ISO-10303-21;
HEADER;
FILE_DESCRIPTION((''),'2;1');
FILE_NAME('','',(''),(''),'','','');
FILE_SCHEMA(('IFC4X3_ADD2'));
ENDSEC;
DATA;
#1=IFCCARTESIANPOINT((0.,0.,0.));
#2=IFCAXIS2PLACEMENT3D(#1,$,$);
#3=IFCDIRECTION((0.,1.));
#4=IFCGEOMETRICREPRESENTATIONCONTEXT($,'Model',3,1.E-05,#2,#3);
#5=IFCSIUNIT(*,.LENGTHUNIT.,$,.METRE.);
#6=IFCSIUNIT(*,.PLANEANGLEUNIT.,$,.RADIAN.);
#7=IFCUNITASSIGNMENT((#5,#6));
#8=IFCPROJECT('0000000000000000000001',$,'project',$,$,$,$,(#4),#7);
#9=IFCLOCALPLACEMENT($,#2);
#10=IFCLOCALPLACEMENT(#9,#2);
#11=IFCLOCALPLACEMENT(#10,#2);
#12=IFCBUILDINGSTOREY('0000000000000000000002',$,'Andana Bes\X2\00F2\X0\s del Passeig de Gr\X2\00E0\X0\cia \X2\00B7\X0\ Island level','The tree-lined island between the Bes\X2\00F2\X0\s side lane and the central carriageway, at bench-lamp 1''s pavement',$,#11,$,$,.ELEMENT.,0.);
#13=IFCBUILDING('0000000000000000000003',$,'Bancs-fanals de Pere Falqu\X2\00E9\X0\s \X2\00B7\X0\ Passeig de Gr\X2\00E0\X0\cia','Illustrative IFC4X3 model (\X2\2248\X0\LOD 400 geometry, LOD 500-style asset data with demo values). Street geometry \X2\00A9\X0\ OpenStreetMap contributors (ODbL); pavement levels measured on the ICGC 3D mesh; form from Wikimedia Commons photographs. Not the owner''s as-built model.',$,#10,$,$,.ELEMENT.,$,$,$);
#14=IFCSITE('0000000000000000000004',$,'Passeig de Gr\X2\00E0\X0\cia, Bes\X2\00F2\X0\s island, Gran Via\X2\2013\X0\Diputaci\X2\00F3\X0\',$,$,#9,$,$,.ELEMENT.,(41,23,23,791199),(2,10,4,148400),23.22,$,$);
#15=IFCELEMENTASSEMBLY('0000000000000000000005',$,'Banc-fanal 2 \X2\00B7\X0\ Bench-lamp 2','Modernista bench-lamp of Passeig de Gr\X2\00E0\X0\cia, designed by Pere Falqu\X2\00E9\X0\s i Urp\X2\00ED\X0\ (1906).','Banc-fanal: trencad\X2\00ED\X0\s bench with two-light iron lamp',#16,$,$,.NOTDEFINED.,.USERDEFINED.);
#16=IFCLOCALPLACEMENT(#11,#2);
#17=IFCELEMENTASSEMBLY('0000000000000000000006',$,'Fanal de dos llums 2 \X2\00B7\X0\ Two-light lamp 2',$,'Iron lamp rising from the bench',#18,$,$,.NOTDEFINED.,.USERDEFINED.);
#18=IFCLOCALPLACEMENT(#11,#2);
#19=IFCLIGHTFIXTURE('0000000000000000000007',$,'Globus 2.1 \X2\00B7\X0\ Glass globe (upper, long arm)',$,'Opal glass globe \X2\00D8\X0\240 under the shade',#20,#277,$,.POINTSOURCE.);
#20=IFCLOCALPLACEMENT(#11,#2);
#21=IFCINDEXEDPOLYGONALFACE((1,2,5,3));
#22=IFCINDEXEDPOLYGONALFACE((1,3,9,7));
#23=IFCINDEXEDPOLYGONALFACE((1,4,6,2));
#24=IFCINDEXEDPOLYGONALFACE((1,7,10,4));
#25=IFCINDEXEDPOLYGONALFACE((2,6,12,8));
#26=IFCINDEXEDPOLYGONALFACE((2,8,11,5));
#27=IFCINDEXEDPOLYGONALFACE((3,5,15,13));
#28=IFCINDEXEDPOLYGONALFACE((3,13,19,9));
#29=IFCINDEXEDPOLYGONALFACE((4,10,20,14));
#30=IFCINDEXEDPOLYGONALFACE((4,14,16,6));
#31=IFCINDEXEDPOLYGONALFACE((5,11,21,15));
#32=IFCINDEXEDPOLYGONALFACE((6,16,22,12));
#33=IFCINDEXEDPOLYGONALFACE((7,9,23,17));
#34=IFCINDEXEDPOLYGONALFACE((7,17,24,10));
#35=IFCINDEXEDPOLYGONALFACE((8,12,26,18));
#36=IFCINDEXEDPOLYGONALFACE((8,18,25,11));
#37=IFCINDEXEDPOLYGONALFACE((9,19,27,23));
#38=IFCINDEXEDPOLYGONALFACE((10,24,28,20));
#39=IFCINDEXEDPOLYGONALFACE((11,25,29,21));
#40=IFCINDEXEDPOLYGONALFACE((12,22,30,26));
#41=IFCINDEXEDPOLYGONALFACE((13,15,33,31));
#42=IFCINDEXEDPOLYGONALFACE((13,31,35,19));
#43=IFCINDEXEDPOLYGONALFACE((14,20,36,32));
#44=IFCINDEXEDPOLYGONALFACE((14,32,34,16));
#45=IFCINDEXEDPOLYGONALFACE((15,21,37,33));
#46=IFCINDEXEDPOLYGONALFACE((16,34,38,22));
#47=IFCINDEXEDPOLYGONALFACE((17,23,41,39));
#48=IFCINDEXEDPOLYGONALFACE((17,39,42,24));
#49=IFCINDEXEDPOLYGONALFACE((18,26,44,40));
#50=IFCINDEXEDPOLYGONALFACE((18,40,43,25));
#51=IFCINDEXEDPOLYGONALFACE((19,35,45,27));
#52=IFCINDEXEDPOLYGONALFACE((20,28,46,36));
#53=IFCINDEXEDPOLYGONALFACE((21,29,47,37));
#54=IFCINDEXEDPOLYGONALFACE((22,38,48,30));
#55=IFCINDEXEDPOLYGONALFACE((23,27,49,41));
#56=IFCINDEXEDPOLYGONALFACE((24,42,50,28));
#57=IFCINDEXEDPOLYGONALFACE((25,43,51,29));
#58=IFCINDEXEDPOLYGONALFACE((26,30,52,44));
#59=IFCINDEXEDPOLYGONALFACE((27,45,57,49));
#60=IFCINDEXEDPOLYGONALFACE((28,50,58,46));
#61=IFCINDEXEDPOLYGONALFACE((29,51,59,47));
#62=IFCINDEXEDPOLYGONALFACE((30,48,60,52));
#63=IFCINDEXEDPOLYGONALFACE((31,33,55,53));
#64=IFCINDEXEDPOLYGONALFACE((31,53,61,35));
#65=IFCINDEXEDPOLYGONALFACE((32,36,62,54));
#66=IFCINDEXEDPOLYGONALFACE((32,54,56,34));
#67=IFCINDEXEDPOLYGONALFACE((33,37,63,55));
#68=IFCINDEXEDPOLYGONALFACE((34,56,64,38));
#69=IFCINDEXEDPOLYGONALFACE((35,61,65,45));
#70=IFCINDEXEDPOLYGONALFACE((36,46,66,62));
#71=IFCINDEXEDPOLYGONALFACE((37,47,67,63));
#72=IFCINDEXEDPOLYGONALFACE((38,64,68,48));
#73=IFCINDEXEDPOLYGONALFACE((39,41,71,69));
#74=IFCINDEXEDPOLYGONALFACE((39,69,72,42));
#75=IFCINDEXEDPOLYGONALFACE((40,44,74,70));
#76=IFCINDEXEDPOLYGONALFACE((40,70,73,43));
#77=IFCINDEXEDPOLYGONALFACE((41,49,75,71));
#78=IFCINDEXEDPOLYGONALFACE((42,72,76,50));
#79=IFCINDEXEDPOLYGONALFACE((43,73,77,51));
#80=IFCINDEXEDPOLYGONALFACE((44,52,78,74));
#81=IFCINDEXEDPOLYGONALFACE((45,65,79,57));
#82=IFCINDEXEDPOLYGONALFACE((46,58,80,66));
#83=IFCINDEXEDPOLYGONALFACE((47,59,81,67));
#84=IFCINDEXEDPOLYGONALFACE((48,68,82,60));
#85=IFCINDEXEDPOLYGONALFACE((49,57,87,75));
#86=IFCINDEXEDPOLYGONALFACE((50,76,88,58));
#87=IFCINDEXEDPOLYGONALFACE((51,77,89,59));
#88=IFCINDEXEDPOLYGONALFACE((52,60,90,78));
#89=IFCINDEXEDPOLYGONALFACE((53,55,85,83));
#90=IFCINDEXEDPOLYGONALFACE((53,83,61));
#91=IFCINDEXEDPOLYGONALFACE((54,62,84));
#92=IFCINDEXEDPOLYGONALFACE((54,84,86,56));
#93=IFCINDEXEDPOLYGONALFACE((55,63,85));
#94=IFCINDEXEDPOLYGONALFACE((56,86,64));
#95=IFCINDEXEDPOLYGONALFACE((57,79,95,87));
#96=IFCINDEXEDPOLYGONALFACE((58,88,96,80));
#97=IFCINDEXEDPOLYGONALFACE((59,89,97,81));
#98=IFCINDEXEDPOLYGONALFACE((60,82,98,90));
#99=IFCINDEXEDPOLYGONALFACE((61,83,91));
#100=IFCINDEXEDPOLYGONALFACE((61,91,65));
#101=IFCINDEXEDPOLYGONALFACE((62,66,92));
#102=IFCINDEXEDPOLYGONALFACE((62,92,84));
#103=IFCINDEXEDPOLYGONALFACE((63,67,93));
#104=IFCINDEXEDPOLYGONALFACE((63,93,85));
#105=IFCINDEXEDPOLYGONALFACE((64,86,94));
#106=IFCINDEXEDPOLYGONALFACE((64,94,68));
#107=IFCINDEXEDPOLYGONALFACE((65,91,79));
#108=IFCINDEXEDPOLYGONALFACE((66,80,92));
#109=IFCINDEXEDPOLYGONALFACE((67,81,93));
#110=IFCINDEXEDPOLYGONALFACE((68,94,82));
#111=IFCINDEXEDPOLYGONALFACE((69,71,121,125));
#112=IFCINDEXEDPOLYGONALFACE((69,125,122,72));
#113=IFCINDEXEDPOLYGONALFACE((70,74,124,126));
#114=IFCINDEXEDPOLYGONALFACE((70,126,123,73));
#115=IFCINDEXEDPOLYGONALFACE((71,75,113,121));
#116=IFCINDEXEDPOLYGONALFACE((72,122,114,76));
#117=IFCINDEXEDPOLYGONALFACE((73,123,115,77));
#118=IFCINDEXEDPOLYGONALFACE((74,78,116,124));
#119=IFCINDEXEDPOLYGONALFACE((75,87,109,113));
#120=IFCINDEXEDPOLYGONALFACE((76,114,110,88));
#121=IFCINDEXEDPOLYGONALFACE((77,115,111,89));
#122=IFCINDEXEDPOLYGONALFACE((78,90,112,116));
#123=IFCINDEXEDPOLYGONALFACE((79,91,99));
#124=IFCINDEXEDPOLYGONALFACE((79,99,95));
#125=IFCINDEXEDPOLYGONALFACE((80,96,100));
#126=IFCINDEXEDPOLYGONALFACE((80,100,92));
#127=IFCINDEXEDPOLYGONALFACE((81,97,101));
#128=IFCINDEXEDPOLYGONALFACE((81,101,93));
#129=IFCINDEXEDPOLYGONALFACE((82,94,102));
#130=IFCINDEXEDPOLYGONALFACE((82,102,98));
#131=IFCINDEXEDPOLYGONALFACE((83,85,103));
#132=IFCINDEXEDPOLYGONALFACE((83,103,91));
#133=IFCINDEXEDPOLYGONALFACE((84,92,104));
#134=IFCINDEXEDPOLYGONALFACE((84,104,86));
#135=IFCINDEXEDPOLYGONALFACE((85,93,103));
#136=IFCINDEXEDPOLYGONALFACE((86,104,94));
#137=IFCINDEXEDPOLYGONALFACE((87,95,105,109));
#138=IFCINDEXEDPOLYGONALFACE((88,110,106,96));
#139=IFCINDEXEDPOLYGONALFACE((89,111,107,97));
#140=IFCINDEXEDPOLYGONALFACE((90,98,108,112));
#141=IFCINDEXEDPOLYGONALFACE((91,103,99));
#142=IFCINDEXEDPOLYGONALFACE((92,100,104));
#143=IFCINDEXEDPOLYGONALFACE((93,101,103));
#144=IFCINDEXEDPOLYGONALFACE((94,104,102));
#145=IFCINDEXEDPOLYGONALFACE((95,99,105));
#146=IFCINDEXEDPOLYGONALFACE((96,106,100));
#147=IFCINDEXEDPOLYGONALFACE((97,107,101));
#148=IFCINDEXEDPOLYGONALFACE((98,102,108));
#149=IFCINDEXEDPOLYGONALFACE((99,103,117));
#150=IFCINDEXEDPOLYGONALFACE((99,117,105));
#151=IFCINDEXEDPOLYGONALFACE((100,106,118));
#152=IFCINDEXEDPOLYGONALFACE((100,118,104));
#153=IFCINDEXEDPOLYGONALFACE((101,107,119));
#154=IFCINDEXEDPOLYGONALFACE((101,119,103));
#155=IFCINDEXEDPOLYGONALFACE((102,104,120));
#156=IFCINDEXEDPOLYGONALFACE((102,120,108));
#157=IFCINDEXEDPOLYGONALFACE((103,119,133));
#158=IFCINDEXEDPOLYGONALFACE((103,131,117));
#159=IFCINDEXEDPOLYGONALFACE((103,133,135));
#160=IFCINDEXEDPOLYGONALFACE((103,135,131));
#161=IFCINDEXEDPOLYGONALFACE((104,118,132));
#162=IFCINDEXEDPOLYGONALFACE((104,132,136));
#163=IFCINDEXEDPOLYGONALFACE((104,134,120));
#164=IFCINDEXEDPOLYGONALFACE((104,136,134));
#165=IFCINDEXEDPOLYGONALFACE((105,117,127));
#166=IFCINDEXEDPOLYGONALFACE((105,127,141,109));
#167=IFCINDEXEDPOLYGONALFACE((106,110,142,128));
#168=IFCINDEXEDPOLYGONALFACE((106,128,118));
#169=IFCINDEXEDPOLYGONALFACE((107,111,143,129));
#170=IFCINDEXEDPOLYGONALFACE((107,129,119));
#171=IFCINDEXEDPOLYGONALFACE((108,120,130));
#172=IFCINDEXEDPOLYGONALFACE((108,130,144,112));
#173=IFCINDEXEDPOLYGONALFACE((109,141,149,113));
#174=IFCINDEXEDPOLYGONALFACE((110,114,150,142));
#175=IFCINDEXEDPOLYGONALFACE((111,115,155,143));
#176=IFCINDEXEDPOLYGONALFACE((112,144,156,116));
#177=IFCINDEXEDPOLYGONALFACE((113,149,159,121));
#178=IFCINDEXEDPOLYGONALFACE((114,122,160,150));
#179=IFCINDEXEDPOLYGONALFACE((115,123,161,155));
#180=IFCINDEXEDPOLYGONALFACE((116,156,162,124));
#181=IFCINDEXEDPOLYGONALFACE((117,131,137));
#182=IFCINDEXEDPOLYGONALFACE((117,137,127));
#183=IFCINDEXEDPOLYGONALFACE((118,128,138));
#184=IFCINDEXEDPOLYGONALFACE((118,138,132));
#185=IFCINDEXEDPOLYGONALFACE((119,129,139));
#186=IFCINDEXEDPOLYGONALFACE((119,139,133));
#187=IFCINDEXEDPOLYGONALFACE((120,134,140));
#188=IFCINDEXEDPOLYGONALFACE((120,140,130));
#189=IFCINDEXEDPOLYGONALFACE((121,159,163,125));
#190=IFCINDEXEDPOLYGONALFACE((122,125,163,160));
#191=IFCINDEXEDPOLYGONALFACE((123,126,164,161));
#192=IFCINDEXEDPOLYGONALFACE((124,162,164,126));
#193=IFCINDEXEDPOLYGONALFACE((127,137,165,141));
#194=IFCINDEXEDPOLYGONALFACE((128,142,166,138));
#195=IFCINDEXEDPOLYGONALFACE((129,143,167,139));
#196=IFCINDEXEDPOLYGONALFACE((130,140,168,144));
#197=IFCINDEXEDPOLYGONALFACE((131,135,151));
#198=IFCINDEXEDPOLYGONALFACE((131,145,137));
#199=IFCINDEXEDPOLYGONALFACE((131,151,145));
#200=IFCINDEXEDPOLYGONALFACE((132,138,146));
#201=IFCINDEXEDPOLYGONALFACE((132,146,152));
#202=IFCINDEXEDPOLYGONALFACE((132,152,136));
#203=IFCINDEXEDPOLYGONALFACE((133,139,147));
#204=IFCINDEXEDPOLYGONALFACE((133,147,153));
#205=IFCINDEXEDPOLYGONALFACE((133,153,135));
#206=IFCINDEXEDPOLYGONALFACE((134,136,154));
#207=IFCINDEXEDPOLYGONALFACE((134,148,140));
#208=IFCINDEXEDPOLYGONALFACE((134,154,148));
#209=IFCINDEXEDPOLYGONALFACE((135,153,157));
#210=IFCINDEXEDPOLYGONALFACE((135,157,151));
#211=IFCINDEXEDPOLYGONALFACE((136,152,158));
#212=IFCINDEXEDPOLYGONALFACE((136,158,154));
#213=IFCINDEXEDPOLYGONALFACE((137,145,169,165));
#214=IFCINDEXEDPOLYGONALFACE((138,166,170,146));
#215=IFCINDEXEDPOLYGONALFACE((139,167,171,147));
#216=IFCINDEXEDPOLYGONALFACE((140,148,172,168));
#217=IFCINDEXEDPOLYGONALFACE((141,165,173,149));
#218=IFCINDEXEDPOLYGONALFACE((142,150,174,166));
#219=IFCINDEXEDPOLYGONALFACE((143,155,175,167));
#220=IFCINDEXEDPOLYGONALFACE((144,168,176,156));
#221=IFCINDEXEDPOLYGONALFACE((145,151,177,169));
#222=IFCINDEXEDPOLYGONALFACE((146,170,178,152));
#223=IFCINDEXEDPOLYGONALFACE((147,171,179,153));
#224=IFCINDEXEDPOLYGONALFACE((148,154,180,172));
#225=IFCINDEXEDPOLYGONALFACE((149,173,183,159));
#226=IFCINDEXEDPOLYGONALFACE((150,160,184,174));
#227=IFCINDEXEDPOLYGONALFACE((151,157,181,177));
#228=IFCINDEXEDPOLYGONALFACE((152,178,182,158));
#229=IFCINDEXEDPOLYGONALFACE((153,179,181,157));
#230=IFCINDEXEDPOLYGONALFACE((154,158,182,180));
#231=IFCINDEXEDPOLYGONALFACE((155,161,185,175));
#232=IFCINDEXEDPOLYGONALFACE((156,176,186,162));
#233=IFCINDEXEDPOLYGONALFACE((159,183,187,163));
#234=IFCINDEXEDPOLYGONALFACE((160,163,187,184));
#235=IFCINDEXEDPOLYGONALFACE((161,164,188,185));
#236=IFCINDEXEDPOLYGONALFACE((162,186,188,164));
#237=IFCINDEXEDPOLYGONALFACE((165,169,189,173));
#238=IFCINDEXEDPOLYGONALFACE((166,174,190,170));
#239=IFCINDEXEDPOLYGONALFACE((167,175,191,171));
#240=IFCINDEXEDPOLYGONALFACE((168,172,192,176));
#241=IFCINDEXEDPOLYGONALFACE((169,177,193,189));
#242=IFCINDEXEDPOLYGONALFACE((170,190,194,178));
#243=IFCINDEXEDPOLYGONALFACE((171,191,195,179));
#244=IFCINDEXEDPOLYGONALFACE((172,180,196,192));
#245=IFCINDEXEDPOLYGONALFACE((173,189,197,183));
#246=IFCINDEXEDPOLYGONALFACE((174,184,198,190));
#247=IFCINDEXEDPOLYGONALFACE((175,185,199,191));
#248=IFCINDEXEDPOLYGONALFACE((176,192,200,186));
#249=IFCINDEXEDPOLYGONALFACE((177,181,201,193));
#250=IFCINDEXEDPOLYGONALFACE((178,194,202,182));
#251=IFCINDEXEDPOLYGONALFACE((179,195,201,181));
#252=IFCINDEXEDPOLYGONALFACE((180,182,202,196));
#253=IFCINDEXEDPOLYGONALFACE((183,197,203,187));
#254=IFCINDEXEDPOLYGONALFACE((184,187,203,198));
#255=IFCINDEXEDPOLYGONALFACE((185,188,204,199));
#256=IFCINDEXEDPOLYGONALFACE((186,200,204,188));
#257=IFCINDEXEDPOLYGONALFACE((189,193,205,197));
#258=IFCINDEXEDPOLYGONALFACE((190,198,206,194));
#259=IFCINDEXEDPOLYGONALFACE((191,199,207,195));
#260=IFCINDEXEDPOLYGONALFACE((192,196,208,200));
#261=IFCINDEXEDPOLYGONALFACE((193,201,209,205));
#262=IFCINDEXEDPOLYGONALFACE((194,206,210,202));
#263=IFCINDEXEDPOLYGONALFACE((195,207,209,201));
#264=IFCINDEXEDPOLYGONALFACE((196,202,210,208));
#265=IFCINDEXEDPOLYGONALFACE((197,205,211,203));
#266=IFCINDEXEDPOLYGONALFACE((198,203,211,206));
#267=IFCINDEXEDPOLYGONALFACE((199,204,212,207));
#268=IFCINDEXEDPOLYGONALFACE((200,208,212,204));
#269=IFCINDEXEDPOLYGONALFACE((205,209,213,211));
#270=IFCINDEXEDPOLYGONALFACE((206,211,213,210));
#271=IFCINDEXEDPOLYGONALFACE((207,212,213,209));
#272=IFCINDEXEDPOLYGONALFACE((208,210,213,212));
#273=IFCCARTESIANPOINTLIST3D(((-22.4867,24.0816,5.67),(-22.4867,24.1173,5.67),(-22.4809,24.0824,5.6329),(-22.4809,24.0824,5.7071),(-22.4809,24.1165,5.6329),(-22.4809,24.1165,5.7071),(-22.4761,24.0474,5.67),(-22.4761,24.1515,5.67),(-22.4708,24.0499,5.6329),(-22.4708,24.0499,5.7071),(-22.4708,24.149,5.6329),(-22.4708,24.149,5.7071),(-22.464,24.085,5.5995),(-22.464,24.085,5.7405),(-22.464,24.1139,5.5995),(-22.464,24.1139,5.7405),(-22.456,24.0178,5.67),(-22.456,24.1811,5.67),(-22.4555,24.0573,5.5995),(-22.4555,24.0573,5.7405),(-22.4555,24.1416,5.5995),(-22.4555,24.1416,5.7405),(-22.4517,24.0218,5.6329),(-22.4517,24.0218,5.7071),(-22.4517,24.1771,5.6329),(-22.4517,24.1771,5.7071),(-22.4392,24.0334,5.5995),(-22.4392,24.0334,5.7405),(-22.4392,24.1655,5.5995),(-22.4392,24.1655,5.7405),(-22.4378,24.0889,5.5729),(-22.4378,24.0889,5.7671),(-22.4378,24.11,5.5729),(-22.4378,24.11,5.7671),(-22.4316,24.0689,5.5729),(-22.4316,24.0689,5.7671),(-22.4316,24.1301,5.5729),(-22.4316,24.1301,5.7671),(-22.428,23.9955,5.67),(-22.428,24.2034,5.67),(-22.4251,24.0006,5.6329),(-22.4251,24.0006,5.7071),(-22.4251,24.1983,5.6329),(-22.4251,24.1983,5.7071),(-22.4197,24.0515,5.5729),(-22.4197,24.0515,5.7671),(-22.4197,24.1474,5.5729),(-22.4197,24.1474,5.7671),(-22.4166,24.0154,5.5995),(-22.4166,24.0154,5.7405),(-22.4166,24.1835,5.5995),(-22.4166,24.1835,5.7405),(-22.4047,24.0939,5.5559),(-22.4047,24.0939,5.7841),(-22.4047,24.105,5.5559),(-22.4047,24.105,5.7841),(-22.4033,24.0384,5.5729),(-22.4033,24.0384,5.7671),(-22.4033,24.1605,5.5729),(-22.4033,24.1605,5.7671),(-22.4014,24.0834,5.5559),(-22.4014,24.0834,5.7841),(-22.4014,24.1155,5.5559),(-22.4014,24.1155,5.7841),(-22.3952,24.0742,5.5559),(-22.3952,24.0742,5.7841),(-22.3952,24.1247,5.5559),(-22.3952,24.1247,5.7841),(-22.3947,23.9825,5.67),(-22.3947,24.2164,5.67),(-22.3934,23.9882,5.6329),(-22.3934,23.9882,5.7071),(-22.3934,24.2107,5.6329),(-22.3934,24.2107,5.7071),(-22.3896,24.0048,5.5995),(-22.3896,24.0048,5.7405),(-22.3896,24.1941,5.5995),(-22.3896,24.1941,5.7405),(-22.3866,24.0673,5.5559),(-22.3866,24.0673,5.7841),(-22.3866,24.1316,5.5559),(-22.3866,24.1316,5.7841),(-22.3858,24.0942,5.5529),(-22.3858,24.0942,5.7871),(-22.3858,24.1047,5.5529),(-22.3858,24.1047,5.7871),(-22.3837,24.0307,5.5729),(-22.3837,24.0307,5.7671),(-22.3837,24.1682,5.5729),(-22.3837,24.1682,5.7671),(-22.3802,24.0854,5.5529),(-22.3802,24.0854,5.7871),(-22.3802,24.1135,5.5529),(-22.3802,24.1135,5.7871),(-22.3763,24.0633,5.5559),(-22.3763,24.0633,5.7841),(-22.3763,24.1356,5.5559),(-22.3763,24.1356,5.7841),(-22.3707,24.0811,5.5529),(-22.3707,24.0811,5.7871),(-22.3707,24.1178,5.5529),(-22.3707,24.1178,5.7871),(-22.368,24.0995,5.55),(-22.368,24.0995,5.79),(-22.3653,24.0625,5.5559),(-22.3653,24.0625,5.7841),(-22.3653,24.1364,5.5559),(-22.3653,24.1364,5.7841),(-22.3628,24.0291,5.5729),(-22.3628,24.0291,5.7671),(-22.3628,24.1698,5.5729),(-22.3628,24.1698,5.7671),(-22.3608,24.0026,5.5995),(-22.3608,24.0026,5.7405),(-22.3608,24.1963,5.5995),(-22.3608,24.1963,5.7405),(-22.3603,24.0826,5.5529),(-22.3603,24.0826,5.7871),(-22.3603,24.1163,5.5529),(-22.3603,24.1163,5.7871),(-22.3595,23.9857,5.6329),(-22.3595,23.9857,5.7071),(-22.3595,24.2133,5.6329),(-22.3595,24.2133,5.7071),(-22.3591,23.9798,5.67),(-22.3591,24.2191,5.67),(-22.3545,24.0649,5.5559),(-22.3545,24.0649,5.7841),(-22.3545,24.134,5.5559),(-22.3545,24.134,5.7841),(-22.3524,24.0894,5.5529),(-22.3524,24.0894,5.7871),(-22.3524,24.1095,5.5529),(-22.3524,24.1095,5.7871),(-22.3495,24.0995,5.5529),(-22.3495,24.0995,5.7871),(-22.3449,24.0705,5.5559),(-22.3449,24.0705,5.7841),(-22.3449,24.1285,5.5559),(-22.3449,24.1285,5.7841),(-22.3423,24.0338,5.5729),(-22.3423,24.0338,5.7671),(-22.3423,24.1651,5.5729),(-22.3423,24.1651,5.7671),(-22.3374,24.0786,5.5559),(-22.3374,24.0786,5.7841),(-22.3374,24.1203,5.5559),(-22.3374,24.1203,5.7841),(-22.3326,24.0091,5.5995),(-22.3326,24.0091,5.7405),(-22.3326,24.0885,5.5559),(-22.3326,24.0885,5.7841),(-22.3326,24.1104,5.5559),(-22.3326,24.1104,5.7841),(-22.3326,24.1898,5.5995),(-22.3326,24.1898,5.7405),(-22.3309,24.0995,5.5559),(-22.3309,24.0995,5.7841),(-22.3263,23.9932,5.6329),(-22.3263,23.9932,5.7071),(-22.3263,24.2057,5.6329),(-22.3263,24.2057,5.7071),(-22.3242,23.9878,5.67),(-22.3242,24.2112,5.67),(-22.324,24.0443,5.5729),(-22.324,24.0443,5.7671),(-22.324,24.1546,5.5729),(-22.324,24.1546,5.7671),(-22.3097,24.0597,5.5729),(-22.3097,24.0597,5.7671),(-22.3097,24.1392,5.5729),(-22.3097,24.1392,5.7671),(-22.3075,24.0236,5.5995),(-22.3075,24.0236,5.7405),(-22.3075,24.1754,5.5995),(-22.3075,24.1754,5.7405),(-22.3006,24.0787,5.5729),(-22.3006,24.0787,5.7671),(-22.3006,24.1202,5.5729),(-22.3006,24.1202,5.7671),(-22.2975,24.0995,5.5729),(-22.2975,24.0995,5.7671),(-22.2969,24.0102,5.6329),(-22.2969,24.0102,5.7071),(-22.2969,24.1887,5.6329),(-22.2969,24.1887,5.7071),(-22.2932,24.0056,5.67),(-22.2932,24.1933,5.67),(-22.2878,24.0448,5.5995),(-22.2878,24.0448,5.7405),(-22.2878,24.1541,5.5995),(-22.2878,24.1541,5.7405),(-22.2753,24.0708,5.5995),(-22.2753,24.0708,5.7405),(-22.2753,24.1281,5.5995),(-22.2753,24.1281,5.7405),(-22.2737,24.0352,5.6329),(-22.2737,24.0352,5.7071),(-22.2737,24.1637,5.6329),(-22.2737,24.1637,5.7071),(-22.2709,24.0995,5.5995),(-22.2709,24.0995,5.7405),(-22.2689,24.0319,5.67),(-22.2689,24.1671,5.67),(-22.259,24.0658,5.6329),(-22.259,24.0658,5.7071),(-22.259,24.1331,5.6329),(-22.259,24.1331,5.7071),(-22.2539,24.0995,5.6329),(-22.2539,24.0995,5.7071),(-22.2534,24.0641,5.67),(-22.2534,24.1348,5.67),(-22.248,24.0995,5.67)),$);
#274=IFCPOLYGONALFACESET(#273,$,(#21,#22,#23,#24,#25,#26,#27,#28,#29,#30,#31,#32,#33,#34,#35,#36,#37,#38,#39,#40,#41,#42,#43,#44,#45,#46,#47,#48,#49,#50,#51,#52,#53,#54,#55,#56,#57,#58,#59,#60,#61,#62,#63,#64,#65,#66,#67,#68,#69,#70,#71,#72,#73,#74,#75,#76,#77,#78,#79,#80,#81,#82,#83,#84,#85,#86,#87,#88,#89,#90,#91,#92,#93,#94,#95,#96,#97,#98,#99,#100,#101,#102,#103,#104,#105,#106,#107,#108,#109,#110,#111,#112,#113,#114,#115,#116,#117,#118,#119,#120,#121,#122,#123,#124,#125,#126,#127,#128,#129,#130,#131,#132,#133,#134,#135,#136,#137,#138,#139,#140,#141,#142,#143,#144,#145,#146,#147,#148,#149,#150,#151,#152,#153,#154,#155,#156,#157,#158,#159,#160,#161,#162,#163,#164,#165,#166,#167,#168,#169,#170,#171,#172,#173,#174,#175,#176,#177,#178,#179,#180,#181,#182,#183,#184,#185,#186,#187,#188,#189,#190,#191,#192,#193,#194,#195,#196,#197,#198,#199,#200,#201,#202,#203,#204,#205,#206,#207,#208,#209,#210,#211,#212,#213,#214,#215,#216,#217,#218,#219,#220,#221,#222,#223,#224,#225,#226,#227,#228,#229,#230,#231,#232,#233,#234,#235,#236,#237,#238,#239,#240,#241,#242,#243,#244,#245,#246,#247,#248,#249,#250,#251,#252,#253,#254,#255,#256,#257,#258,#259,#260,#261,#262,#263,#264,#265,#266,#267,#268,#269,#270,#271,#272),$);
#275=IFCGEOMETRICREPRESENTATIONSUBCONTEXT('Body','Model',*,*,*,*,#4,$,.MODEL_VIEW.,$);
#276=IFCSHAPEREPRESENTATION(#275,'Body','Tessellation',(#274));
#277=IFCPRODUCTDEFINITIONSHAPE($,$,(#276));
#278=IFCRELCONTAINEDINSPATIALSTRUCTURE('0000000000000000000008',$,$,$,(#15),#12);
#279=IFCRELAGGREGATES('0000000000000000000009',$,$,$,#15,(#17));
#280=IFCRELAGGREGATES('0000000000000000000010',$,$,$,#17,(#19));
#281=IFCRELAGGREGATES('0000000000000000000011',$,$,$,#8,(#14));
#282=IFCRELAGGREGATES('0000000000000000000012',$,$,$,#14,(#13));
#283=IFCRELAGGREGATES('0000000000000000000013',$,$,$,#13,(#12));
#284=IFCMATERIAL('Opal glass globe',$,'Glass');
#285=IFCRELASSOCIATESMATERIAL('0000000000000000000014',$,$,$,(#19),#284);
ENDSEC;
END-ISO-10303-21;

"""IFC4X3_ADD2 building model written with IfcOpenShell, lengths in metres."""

from ifc_helpers import new_model, entity, si_unit, direction, origin, place, context, subcontext, project, spatial, material, element, aggregate, save


model = new_model("IFC4X3_ADD2")

# Units and contexts
model_context = context("Model", 3, precision=1e-05, world=origin(), true_north=direction((0.0, 1.0)))
body_context = subcontext(model_context, "Body", "Model", "MODEL_VIEW")
ifc_project = project(units=[si_unit("LENGTHUNIT", "METRE"), si_unit("PLANEANGLEUNIT", "RADIAN")], contexts=[model_context])

# Site, building, storey
site_placement = place(None, origin())
site = spatial("IfcSite", under=ifc_project, at=site_placement, Name="Passeig de Gràcia, Besòs island, Gran Via–Diputació", CompositionType="ELEMENT", RefLatitude=(41, 23, 23, 791199), RefLongitude=(2, 10, 4, 148400), RefElevation=23.22)
building_placement = place(site_placement, origin())
building = spatial("IfcBuilding", under=site, at=building_placement, Name="Bancs-fanals de Pere Falqués · Passeig de Gràcia", Description="Illustrative IFC4X3 model (≈LOD 400 geometry, LOD 500-style asset data with demo values). Street geometry © OpenStreetMap contributors (ODbL); pavement levels measured on the ICGC 3D mesh; form from Wikimedia Commons photographs. Not the owner's as-built model.", CompositionType="ELEMENT")
storey_placement = place(building_placement, origin())
storey = spatial("IfcBuildingStorey", under=building, at=storey_placement, Name="Andana Besòs del Passeig de Gràcia · Island level", Description="The tree-lined island between the Besòs side lane and the central carriageway, at bench-lamp 1's pavement", CompositionType="ELEMENT", Elevation=0.0)

# Element assemblies
assembly_1_placement = place(building_placement, origin())
assembly_1 = element("IfcElementAssembly", 1, at=assembly_1_placement, inside=storey, Name="Banc-fanal 2 · Bench-lamp 2", Description="Modernista bench-lamp of Passeig de Gràcia, designed by Pere Falqués i Urpí (1906).", ObjectType="Banc-fanal: trencadís bench with two-light iron lamp", AssemblyPlace="NOTDEFINED", PredefinedType="USERDEFINED")
assembly_2_placement = place(building_placement, origin())
assembly_2 = element("IfcElementAssembly", 2, at=assembly_2_placement, Name="Fanal de dos llums 2 · Two-light lamp 2", ObjectType="Iron lamp rising from the bench", AssemblyPlace="NOTDEFINED", PredefinedType="USERDEFINED")
aggregate(assembly_1, [assembly_2])

# Light fixture
ifc_material_1 = material(Name="Opal glass globe", Category="Glass")
light_fixture_1_placement = place(building_placement, origin())
light_fixture_1 = element("IfcLightFixture", 3, at=light_fixture_1_placement, material=ifc_material_1, Name="Globus 2.1 · Glass globe (upper, long arm)", ObjectType="Opal glass globe Ø240 under the shade", PredefinedType="POINTSOURCE", context=body_context, shape_type="SweptSolid", body=[
    entity("IfcRevolvedAreaSolid", entity("IfcArbitraryClosedProfileDef", "AREA", None, entity("IfcPolyline", [entity("IfcCartesianPoint", [0.0, -0.12]), entity("IfcCartesianPoint", [0.0371, -0.1141]), entity("IfcCartesianPoint", [0.0705, -0.0971]), entity("IfcCartesianPoint", [0.0971, -0.0705]), entity("IfcCartesianPoint", [0.1141, -0.0371]), entity("IfcCartesianPoint", [0.12, 0.0]), entity("IfcCartesianPoint", [0.1141, 0.0371]), entity("IfcCartesianPoint", [0.0971, 0.0705]), entity("IfcCartesianPoint", [0.0705, 0.0971]), entity("IfcCartesianPoint", [0.0371, 0.1141]), entity("IfcCartesianPoint", [0.0, 0.12]), entity("IfcCartesianPoint", [0.0, -0.12])])), entity("IfcAxis2Placement3D", entity("IfcCartesianPoint", [-22.368, 24.0995, 5.67]), entity("IfcDirection", [0.0, -1.0, 0.0]), entity("IfcDirection", [1.0, 0.0, 0.0])), entity("IfcAxis1Placement", entity("IfcCartesianPoint", [0.0, 0.0, 0.0]), entity("IfcDirection", [0.0, 1.0, 0.0])), 6.283185),
])

aggregate(assembly_2, [light_fixture_1])

save(model, "model.ifc")
